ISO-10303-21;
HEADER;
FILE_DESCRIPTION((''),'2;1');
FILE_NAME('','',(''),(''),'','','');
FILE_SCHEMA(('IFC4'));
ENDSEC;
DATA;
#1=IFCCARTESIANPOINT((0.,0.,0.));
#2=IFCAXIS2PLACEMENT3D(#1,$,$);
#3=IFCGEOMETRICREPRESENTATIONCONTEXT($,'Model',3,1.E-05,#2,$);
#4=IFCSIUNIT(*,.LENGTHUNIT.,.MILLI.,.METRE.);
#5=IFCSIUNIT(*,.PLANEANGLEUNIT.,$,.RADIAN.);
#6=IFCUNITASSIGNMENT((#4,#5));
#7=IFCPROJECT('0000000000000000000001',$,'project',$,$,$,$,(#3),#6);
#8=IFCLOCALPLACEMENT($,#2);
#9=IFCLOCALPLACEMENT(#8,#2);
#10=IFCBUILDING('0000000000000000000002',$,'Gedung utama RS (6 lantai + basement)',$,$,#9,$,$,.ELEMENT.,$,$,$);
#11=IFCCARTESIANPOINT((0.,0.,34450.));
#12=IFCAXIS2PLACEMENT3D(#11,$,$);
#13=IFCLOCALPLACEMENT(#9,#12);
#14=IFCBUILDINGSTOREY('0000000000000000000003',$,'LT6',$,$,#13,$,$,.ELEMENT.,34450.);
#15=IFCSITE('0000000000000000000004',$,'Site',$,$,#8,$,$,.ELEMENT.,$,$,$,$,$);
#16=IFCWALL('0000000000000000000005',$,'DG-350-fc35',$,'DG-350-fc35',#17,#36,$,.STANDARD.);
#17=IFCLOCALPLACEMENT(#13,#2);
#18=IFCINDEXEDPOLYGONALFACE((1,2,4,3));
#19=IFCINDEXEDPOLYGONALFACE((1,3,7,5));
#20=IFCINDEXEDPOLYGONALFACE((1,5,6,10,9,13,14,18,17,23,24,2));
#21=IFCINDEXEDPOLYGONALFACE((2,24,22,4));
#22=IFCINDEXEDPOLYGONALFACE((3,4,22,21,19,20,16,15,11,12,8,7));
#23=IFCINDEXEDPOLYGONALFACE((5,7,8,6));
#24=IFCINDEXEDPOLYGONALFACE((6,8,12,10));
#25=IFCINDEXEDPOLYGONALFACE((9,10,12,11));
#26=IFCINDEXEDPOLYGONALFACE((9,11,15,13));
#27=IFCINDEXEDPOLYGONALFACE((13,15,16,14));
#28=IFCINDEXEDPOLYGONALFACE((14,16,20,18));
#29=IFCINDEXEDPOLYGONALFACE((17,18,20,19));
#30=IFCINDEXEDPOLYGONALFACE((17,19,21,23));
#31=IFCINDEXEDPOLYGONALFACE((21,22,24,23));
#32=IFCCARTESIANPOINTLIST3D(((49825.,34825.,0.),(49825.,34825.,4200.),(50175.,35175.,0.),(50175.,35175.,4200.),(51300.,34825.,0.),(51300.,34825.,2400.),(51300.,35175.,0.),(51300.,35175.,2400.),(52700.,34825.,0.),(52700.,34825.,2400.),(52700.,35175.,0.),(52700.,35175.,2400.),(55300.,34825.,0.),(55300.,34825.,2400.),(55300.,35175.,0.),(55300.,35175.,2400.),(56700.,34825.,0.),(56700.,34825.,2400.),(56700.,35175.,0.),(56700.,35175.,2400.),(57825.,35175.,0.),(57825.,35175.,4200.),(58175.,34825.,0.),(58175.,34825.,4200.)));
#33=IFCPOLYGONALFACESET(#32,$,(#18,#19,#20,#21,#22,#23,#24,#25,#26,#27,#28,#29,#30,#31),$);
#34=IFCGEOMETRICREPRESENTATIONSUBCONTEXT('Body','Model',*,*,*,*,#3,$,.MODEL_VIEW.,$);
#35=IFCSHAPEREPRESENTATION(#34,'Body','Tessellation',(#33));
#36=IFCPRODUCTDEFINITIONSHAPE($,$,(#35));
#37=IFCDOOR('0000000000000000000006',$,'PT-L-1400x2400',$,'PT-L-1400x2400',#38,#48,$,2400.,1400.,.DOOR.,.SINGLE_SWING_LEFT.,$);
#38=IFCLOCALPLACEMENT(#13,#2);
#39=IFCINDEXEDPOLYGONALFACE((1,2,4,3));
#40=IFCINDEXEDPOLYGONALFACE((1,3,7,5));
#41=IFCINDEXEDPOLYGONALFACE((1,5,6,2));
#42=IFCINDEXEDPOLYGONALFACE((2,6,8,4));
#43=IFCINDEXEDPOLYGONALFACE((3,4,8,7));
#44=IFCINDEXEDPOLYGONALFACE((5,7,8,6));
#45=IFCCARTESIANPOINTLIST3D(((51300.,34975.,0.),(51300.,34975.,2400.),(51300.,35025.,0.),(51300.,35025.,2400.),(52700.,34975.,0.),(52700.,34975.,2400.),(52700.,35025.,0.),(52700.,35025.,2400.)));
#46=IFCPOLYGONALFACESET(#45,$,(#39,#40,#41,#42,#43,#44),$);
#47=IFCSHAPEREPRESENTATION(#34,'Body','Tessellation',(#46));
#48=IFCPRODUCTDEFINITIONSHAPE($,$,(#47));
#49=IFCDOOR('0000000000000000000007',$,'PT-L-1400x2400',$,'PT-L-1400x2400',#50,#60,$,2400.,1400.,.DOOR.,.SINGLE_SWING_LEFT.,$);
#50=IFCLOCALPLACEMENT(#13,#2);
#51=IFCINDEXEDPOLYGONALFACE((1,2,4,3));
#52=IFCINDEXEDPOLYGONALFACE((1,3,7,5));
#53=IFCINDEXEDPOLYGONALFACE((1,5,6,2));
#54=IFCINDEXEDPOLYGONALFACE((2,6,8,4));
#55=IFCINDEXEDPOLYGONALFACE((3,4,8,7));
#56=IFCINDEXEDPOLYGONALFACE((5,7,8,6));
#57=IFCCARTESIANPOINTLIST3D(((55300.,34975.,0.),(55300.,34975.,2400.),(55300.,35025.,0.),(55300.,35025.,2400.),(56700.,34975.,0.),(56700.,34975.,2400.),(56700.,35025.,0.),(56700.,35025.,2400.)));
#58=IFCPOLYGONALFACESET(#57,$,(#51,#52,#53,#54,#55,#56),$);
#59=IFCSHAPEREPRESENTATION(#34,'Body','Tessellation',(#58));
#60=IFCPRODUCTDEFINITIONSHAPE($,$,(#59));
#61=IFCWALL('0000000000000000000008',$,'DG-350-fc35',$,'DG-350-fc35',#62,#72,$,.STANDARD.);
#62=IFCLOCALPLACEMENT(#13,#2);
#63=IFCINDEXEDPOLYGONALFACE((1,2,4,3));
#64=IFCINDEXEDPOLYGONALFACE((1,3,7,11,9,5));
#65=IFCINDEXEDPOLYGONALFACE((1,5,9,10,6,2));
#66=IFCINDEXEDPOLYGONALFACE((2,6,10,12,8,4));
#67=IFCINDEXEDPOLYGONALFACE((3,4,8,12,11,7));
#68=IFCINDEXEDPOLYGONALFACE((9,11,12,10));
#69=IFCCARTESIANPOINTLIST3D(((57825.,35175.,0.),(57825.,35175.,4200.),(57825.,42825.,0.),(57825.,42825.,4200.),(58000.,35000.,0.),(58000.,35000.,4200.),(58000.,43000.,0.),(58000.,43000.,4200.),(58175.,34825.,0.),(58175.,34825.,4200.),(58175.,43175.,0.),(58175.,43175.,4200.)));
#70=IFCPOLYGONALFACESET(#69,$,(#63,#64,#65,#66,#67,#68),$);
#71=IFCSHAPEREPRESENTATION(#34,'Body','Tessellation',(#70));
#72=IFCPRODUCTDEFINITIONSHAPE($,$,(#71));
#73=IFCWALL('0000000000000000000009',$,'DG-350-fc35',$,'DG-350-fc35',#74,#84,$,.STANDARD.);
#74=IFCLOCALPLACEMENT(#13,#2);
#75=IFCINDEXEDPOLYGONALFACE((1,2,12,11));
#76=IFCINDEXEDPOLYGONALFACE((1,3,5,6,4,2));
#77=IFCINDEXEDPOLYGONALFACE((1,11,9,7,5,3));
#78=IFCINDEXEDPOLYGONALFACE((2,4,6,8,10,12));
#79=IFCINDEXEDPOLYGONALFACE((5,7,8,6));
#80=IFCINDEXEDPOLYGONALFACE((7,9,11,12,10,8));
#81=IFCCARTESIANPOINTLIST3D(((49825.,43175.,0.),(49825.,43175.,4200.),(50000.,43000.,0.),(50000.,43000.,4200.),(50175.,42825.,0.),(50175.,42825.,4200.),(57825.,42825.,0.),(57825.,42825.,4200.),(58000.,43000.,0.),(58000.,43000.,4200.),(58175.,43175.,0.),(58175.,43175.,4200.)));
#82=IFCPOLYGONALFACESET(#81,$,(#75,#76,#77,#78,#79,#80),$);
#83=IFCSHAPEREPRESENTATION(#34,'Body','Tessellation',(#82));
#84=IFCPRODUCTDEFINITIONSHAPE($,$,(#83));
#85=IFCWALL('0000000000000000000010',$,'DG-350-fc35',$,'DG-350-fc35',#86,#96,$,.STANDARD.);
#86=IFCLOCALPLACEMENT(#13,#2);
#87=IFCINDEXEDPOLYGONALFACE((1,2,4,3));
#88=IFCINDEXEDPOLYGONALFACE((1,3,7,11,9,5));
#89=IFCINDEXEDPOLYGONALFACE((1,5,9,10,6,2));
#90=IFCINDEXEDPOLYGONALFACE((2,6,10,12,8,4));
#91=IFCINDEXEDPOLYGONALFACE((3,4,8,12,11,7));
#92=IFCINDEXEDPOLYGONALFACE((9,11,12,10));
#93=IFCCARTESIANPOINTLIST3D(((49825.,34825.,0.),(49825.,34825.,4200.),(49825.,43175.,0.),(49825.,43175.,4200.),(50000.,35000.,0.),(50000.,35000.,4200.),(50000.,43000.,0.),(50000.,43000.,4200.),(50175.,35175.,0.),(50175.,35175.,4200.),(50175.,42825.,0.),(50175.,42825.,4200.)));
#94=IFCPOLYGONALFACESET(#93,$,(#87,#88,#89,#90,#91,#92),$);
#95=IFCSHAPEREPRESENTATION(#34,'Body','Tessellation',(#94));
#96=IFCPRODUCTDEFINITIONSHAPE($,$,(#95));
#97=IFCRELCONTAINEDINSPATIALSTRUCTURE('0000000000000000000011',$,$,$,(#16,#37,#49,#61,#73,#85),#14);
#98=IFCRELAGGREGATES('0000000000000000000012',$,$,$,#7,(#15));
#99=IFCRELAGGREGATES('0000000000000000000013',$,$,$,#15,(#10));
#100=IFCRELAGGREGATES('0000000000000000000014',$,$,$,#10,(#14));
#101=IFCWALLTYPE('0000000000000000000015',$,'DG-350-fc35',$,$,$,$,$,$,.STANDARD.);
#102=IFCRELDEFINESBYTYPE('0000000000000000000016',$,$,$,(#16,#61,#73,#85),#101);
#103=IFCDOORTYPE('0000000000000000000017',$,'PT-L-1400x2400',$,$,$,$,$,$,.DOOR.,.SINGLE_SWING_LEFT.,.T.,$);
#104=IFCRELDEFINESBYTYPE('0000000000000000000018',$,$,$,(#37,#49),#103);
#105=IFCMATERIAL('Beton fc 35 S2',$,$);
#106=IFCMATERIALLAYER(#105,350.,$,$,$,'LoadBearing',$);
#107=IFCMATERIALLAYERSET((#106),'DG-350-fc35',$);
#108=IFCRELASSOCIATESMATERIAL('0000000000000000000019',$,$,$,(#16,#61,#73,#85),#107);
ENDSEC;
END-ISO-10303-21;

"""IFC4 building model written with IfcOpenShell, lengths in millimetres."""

from ifc_helpers import new_model, si_unit, frame, frame_2d, origin, place, context, subcontext, project, spatial, polyline, rectangle, outline, extrude, material, layer, layer_set, layer_usage, type_object, element, fill, save


model = new_model("IFC4")

# Units and contexts
model_context = context("Model", 3, precision=1e-05, world=origin())
body_context = subcontext(model_context, "Body", "Model", "MODEL_VIEW")
ifc_project = project(units=[si_unit("LENGTHUNIT", "METRE", prefix="MILLI"), si_unit("PLANEANGLEUNIT", "RADIAN")], contexts=[model_context])

# Site, building, storey
site_placement = place(None, origin())
site = spatial("IfcSite", under=ifc_project, at=site_placement, Name="Site", CompositionType="ELEMENT")
building_placement = place(site_placement, origin())
building = spatial("IfcBuilding", under=site, at=building_placement, Name="Gedung utama RS (6 lantai + basement)", CompositionType="ELEMENT")
storey_placement = place(building_placement, frame((0.0, 0.0, 34450.0)))
storey = spatial("IfcBuildingStorey", under=building, at=storey_placement, Name="LT6", CompositionType="ELEMENT", Elevation=34450.0)

# Shared definitions
ifc_material_1 = material(Name="Beton fc 35 S2")
ifc_layer = layer(ifc_material_1, 350.0, Category="LoadBearing")
ifc_layer_set = layer_set([ifc_layer], Name="DG-350-fc35")
ifc_layer_usage = layer_usage(ifc_layer_set, "AXIS2", "NEGATIVE", 175.0)
wall_type = type_object("IfcWallType", Name="DG-350-fc35", PredefinedType="STANDARD")

# Wall, openings, doors
wall_1_placement = place(storey_placement, frame((50000.0, 35000.0, 0.0), z_axis=(0.0, 0.0, 1.0), x_axis=(1.0, 0.0, 0.0)))
wall_1 = element("IfcWall", 1, at=wall_1_placement, inside=storey, type_object=wall_type, material=ifc_layer_usage, Name="DG-350-fc35", ObjectType="DG-350-fc35", PredefinedType="STANDARD", context=body_context, shape_type="SweptSolid", body=[
    extrude(outline(polyline([(-175.0, -175.0), (0.0, 0.0), (175.0, 175.0), (7825.0, 175.0), (8000.0, 0.0), (8175.0, -175.0), (-175.0, -175.0)])), origin(), (0.0, 0.0, 1.0), 4200.0),
])
opening_1_placement = place(wall_1_placement, frame((1300.0, 0.0, 0.0), z_axis=(0.0, 0.0, 1.0), x_axis=(1.0, 0.0, 0.0)))
opening_1 = element("IfcOpeningElement", 2, at=opening_1_placement, cuts=wall_1, PredefinedType="OPENING", context=body_context, shape_type="SweptSolid", body=[
    extrude(rectangle(XDim=1400.0, YDim=370.0, at=frame_2d((700.0, 0.0))), origin(), (0.0, 0.0, 1.0), 2400.0),
])
opening_2_placement = place(wall_1_placement, frame((5300.0, 0.0, 0.0), z_axis=(0.0, 0.0, 1.0), x_axis=(1.0, 0.0, 0.0)))
opening_2 = element("IfcOpeningElement", 3, at=opening_2_placement, cuts=wall_1, PredefinedType="OPENING", context=body_context, shape_type="SweptSolid", body=[
    extrude(rectangle(XDim=1400.0, YDim=370.0, at=frame_2d((700.0, 0.0))), origin(), (0.0, 0.0, 1.0), 2400.0),
])
door_type = type_object("IfcDoorType", Name="PT-L-1400x2400", OperationType="SINGLE_SWING_LEFT", ParameterTakesPrecedence=True, PredefinedType="DOOR")
door_1_placement = place(opening_1_placement, origin())
door_1 = element("IfcDoor", 4, at=door_1_placement, inside=storey, type_object=door_type, Name="PT-L-1400x2400", ObjectType="PT-L-1400x2400", OperationType="SINGLE_SWING_LEFT", OverallHeight=2400.0, OverallWidth=1400.0, PredefinedType="DOOR", context=body_context, shape_type="SweptSolid", body=[
    extrude(rectangle(XDim=1400.0, YDim=50.0, at=frame_2d((700.0, 0.0))), origin(), (0.0, 0.0, 1.0), 2400.0),
])
fill(opening_1, door_1)
door_2_placement = place(opening_2_placement, origin())
door_2 = element("IfcDoor", 5, at=door_2_placement, inside=storey, type_object=door_type, Name="PT-L-1400x2400", ObjectType="PT-L-1400x2400", OperationType="SINGLE_SWING_LEFT", OverallHeight=2400.0, OverallWidth=1400.0, PredefinedType="DOOR", context=body_context, shape_type="SweptSolid", body=[
    extrude(rectangle(XDim=1400.0, YDim=50.0, at=frame_2d((700.0, 0.0))), origin(), (0.0, 0.0, 1.0), 2400.0),
])
fill(opening_2, door_2)

# Walls
for number, where, z_axis, x_axis, name in (
    (6, (58000.0, 35000.0, 0.0), (0.0, 0.0, 1.0), (0.0, 1.0, 0.0), "DG-350-fc35"),
    (7, (58000.0, 43000.0, 0.0), (0.0, 0.0, 1.0), (-1.0, 0.0, 0.0), "DG-350-fc35"),
    (8, (50000.0, 43000.0, 0.0), (0.0, 0.0, 1.0), (0.0, -1.0, 0.0), "DG-350-fc35"),
):
    element("IfcWall", number, at=place(storey_placement, frame(where, z_axis=z_axis, x_axis=x_axis)), inside=storey, type_object=wall_type, material=ifc_layer_usage, Name=name, ObjectType="DG-350-fc35", PredefinedType="STANDARD", context=body_context, shape_type="SweptSolid", body=[
        extrude(outline(polyline([(-175.0, -175.0), (0.0, 0.0), (175.0, 175.0), (7825.0, 175.0), (8000.0, 0.0), (8175.0, -175.0), (-175.0, -175.0)])), origin(), (0.0, 0.0, 1.0), 4200.0),
    ])

save(model, "model.ifc")
